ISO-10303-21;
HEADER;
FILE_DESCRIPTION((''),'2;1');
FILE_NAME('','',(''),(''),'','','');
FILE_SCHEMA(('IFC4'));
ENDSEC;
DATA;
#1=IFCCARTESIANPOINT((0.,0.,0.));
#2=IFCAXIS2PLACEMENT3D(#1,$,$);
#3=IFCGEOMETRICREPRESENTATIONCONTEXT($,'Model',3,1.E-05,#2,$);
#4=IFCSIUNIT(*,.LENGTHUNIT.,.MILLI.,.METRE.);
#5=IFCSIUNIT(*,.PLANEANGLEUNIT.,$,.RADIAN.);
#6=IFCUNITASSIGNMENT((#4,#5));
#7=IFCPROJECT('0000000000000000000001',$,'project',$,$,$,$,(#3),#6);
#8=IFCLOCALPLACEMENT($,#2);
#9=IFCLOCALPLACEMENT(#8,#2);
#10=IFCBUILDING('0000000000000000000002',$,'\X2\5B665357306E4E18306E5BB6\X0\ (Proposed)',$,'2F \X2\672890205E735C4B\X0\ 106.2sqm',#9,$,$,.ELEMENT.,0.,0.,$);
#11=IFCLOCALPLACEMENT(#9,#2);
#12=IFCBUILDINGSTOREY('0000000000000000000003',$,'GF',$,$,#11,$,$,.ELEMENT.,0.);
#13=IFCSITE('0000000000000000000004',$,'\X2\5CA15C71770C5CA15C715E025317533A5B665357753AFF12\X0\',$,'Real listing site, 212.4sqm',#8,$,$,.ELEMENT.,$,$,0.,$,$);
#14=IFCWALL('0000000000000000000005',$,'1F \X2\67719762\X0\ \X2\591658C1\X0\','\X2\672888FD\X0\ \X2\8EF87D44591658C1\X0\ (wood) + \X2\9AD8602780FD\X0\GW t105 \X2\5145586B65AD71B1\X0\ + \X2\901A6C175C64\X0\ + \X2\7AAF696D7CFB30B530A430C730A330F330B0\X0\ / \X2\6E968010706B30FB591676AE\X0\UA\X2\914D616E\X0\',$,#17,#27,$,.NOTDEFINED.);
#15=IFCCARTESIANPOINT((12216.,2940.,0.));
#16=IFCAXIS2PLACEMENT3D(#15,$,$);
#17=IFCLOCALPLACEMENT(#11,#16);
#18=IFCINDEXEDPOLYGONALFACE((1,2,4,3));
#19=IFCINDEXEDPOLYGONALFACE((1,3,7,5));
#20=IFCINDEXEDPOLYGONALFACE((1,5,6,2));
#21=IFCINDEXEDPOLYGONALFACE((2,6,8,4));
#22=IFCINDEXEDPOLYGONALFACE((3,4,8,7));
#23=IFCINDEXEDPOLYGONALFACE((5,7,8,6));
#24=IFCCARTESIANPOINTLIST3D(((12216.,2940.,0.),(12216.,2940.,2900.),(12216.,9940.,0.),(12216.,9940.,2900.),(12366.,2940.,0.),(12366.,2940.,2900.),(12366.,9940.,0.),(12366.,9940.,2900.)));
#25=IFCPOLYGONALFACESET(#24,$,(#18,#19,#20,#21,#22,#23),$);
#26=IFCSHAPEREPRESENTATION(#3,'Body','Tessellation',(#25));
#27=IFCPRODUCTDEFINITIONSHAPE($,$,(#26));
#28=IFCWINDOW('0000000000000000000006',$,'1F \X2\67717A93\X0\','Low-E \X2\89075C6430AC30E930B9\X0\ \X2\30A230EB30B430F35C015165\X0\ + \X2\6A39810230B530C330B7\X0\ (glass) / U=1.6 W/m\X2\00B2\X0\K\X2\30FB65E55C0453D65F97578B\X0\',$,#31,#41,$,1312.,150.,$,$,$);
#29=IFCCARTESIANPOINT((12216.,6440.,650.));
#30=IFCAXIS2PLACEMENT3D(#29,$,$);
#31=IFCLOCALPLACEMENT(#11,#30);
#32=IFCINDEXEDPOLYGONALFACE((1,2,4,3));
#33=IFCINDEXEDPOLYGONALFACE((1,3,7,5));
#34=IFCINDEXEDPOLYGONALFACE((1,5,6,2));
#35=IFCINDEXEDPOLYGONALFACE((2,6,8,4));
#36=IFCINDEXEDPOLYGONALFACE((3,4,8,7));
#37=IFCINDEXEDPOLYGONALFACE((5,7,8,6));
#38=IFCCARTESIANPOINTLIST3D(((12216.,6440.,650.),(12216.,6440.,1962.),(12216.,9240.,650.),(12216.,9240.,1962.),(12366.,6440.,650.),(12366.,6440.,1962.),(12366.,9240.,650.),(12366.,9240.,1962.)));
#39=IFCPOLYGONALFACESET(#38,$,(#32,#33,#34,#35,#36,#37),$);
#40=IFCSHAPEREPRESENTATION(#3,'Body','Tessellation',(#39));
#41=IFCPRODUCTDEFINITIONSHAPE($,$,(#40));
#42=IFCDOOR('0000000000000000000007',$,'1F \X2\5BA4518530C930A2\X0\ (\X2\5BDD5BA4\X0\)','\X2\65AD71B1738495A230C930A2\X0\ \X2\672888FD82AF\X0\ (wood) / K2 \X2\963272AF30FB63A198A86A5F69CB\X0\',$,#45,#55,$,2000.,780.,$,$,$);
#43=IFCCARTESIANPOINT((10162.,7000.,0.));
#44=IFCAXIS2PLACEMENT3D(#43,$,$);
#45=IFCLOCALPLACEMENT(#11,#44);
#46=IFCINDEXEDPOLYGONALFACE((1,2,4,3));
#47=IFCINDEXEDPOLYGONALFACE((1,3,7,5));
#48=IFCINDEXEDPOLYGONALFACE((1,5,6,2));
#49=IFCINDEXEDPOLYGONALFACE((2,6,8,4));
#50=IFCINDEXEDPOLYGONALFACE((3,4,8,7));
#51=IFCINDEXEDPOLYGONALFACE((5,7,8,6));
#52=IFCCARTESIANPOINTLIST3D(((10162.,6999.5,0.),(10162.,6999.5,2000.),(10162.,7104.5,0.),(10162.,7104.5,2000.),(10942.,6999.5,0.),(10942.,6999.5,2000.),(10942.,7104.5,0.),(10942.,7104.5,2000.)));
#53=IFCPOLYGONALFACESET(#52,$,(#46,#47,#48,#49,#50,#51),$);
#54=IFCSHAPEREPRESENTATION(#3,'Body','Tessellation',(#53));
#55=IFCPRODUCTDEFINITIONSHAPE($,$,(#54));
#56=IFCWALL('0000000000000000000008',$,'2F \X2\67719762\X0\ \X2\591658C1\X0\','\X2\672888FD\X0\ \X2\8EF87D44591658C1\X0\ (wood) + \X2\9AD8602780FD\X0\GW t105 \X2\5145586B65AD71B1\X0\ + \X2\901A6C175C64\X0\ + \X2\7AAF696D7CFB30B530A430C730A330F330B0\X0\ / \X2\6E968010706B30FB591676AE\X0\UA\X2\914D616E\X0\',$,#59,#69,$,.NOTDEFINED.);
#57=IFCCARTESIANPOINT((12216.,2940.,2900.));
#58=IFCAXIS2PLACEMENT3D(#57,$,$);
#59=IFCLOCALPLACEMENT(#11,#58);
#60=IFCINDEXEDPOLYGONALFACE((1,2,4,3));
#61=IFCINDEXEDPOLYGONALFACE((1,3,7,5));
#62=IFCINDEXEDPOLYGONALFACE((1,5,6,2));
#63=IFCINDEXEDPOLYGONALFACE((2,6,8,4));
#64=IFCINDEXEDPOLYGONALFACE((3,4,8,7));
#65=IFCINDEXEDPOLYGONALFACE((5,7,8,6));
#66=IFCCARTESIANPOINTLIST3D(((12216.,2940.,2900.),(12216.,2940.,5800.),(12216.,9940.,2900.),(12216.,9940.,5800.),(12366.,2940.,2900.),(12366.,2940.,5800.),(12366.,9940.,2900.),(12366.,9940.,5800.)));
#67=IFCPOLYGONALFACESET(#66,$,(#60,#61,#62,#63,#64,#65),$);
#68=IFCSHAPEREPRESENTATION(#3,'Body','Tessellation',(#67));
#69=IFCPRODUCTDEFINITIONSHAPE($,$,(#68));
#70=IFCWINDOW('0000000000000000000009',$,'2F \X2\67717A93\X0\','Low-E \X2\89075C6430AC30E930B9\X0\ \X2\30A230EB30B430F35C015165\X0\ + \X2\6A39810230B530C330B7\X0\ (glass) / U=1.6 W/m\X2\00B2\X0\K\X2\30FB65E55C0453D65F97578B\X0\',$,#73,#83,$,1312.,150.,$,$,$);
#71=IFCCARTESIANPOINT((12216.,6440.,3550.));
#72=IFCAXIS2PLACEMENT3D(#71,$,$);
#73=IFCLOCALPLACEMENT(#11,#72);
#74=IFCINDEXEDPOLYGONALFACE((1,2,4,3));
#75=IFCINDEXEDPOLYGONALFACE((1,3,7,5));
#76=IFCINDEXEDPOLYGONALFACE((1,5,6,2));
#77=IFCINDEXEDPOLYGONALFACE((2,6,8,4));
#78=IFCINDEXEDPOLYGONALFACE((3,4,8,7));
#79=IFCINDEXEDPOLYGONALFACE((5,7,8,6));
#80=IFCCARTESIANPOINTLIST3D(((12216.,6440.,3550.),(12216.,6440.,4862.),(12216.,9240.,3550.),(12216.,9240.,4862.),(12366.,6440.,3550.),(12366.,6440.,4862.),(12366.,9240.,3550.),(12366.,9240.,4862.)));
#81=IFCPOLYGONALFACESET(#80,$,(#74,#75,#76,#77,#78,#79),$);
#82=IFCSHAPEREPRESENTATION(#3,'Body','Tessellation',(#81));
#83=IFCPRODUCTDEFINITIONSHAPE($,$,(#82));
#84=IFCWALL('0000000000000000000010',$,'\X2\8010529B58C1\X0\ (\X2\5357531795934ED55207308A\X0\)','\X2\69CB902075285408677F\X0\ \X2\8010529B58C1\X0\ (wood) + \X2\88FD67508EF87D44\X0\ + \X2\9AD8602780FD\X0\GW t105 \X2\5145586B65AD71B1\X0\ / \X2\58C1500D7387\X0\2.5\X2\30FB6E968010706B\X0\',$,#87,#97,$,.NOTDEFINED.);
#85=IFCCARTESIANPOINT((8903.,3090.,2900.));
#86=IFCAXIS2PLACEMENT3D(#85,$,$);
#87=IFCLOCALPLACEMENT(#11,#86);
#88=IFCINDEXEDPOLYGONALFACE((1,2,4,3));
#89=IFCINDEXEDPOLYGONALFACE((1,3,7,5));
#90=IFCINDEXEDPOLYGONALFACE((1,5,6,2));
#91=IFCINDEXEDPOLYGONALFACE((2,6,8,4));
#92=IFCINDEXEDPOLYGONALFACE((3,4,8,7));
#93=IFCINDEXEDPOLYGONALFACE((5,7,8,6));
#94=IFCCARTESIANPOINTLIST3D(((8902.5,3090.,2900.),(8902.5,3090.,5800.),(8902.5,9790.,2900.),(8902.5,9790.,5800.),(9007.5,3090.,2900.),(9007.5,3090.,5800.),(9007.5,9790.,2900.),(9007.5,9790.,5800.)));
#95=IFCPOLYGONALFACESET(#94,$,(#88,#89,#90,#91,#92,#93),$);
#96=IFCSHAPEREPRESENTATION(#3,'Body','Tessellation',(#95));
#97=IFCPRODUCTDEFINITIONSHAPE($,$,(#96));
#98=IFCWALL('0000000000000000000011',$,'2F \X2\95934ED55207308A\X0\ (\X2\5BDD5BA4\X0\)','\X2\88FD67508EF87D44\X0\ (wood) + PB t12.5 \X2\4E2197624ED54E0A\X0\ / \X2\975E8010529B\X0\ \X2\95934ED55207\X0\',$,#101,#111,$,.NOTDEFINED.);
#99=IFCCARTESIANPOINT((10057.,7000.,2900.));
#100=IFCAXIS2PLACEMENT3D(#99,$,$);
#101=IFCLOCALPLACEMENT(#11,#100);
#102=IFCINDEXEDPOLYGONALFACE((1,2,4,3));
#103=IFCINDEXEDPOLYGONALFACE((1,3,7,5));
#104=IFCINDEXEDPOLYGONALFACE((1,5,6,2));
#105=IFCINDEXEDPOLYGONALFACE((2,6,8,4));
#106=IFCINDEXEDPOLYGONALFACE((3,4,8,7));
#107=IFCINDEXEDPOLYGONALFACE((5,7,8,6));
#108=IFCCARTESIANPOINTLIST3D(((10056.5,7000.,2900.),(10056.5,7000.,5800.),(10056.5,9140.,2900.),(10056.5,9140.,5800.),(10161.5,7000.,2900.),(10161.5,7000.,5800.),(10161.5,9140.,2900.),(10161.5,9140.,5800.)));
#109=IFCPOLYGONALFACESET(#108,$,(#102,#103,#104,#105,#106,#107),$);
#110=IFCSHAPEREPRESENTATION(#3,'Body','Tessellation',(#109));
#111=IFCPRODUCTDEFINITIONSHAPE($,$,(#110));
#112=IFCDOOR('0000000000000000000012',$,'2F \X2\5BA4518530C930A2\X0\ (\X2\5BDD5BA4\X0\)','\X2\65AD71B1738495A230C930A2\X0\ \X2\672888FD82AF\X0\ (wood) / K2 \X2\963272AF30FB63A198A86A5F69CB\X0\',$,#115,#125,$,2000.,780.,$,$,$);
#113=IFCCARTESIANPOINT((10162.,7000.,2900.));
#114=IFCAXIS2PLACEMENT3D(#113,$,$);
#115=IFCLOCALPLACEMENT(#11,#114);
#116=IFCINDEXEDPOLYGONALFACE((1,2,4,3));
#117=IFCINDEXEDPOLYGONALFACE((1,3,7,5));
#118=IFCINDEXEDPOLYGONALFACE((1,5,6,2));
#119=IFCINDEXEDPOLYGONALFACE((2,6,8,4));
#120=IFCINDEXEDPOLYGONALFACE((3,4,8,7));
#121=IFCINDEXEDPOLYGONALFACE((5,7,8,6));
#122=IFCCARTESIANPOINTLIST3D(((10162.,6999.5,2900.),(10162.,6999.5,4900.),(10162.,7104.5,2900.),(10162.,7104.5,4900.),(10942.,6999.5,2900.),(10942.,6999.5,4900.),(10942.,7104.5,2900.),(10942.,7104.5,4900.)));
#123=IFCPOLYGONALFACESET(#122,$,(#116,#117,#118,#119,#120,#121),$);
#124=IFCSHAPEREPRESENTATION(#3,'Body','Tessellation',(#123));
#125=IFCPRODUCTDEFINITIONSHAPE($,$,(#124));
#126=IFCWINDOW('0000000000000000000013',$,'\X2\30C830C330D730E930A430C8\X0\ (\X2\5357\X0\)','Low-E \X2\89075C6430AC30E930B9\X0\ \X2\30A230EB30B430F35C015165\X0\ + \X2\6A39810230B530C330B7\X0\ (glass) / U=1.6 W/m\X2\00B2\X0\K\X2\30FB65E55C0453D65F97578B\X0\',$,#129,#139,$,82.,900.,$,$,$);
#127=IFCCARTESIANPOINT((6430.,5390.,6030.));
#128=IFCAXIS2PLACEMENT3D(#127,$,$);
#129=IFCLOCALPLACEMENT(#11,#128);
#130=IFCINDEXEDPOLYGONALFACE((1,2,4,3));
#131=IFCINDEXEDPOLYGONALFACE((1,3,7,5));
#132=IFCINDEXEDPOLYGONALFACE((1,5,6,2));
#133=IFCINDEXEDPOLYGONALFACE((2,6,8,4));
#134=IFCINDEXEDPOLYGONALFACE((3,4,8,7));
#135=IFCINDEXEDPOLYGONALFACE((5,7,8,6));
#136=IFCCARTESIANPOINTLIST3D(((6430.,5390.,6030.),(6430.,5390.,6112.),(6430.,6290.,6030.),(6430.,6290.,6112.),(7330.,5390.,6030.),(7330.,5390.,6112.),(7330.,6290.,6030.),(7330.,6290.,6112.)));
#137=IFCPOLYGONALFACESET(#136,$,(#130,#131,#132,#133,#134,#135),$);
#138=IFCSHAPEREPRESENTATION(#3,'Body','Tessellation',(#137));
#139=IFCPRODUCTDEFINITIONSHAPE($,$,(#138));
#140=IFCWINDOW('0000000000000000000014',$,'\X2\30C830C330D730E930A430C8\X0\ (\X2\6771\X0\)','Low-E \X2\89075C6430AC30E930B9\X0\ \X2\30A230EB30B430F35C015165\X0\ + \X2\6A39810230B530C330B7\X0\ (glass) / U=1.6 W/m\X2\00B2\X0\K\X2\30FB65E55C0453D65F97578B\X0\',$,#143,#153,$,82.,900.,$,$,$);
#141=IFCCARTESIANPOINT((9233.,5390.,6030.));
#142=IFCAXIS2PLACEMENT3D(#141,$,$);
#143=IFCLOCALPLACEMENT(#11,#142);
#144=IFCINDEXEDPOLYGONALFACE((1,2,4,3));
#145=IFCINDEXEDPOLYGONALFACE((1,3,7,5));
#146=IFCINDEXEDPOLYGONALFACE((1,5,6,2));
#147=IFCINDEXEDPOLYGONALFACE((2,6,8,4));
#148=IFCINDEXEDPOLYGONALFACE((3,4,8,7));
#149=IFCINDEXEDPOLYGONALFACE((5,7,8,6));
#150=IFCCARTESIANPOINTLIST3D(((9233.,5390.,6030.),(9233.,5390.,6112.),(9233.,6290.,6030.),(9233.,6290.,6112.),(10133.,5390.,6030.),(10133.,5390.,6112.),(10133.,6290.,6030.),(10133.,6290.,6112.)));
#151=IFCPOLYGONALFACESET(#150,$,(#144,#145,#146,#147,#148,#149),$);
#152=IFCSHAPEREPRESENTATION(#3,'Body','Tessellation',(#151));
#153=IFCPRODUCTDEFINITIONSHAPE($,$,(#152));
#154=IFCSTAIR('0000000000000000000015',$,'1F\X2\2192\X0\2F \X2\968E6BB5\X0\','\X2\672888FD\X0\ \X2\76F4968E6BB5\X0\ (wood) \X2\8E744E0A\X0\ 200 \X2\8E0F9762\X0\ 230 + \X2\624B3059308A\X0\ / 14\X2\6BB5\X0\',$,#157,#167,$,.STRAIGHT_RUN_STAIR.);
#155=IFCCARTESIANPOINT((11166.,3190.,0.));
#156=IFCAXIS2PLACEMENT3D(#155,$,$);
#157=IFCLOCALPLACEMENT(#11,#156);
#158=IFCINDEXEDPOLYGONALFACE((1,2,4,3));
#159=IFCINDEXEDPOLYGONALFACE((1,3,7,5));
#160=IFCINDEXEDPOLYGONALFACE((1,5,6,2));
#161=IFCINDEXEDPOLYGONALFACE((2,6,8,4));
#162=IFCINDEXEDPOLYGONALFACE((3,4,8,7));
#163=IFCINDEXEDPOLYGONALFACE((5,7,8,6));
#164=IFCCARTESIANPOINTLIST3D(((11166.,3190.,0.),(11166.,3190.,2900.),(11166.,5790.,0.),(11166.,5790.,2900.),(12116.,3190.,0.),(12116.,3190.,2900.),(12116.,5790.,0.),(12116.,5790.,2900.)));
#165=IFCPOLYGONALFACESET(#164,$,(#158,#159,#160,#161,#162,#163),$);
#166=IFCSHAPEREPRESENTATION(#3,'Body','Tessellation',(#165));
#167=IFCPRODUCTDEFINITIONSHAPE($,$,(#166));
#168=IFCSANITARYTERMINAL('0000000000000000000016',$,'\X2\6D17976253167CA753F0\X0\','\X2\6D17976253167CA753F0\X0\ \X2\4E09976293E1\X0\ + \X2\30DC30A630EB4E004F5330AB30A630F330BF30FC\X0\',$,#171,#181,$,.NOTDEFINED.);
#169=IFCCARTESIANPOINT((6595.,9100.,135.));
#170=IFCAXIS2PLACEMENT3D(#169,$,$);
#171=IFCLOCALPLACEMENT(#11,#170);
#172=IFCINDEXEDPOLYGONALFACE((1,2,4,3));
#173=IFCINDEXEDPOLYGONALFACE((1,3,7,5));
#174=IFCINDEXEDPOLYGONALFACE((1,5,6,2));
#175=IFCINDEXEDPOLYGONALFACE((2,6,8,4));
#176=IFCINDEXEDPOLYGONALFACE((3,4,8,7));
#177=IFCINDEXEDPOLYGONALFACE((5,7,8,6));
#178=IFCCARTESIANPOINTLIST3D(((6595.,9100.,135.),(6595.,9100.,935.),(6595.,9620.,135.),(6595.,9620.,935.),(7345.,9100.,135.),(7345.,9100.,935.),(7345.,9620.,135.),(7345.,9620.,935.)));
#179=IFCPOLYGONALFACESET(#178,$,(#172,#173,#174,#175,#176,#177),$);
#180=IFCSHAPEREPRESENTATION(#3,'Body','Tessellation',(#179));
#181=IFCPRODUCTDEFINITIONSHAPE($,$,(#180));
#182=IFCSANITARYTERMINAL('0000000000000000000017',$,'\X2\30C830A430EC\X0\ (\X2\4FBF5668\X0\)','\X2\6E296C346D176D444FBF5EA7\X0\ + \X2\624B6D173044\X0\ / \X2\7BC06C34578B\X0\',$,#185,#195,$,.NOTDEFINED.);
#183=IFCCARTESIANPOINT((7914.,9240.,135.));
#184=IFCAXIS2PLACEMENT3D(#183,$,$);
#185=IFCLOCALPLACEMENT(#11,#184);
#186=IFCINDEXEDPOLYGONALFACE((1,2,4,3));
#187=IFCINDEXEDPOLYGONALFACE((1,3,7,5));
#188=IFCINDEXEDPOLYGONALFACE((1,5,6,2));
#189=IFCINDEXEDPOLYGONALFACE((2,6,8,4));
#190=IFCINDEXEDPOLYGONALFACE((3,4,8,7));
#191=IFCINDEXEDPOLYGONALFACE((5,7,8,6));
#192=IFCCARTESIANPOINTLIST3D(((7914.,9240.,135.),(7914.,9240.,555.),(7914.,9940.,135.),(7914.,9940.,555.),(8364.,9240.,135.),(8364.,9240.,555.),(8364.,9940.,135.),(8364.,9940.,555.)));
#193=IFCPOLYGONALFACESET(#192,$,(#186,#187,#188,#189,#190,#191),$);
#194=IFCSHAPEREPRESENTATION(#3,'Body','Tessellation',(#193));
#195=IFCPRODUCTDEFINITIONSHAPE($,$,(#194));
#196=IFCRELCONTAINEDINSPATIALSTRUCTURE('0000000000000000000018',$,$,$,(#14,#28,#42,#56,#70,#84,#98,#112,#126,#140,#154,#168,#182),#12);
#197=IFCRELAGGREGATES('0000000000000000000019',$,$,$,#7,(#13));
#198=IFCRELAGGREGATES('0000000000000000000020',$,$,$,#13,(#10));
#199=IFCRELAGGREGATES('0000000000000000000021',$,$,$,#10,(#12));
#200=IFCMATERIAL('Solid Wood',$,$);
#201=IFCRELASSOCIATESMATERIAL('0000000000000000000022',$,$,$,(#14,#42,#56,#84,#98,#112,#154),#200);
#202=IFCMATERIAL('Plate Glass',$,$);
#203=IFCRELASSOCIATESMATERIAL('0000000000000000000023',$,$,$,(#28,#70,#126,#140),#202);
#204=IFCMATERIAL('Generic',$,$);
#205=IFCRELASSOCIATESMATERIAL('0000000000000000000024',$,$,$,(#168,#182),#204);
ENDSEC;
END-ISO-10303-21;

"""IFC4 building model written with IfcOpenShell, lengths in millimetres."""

from ifc_helpers import new_model, si_unit, frame, frame_2d, origin, place, context, project, spatial, rectangle, extrude, material, element, fill, save


model = new_model("IFC4")

# Units and contexts
model_context = context("Model", 3, precision=1e-05, world=origin())
ifc_project = project(units=[si_unit("LENGTHUNIT", "METRE", prefix="MILLI"), si_unit("PLANEANGLEUNIT", "RADIAN")], contexts=[model_context])

# Site, building, storey
site_placement = place(None, origin())
site = spatial("IfcSite", under=ifc_project, at=site_placement, Name="岡山県岡山市北区学南町２", ObjectType="Real listing site, 212.4sqm", CompositionType="ELEMENT", RefElevation=0.0)
building_placement = place(site_placement, origin())
building = spatial("IfcBuilding", under=site, at=building_placement, Name="学南の丘の家 (Proposed)", ObjectType="2F 木造平屋 106.2sqm", CompositionType="ELEMENT", ElevationOfRefHeight=0.0, ElevationOfTerrain=0.0)
storey_placement = place(building_placement, origin())
storey = spatial("IfcBuildingStorey", under=building, at=storey_placement, Name="GF", CompositionType="ELEMENT", Elevation=0.0)

# Wall, opening, window
ifc_material_1 = material(Name="Solid Wood")
wall_1_placement = place(storey_placement, frame((12216.0, 2940.0, 0.0)))
wall_1 = element("IfcWall", 1, at=wall_1_placement, inside=storey, material=ifc_material_1, Name="1F 東面 外壁", Description="木製 軸組外壁 (wood) + 高性能GW t105 充填断熱 + 通気層 + 窯業系サイディング / 準耐火・外皮UA配慮", PredefinedType="NOTDEFINED", context=model_context, shape_type="SweptSolid", body=[
    extrude(rectangle(XDim=150.0, YDim=7000.0, at=frame_2d((75.0, 3500.0))), frame((12216.0, 2940.0, 0.0)), (0.0, 0.0, 1.0), 2900.0),
])
opening_1_placement = place(storey_placement, frame((12216.0, 6440.0, 650.0)))
opening_1 = element("IfcOpeningElement", 2, at=opening_1_placement, cuts=wall_1, PredefinedType="NOTDEFINED", context=model_context, shape_type="SweptSolid", body=[
    extrude(rectangle(XDim=150.0, YDim=2800.0, at=frame_2d((75.0, 1400.0))), frame((12216.0, 6440.0, 650.0)), (0.0, 0.0, 1.0), 1312.0),
])
ifc_material_2 = material(Name="Plate Glass")
window_1_placement = place(storey_placement, frame((12216.0, 6440.0, 650.0)))
window_1 = element("IfcWindow", 3, at=window_1_placement, inside=storey, material=ifc_material_2, Name="1F 東窓", Description="Low-E 複層ガラス アルゴン封入 + 樹脂サッシ (glass) / U=1.6 W/m²K・日射取得型", OverallHeight=1312.0, OverallWidth=150.0, context=model_context, shape_type="SweptSolid", body=[
    extrude(rectangle(XDim=150.0, YDim=2800.0, at=frame_2d((75.0, 1400.0))), frame((12216.0, 6440.0, 650.0)), (0.0, 0.0, 1.0), 1312.0),
])
fill(opening_1, window_1)

# Door
door_1_placement = place(storey_placement, frame((10162.0, 7000.0, 0.0)))
element("IfcDoor", 4, at=door_1_placement, inside=storey, material=ifc_material_1, Name="1F 室内ドア (寝室)", Description="断熱玄関ドア 木製芯 (wood) / K2 防犯・採風機構", OverallHeight=2000.0, OverallWidth=780.0, context=model_context, shape_type="SweptSolid", body=[
    extrude(rectangle(XDim=780.0, YDim=105.0, at=frame_2d((390.0, 52.0))), frame((10162.0, 7000.0, 0.0)), (0.0, 0.0, 1.0), 2000.0),
])

# Wall, opening, window
wall_2_placement = place(storey_placement, frame((12216.0, 2940.0, 2900.0)))
wall_2 = element("IfcWall", 5, at=wall_2_placement, inside=storey, material=ifc_material_1, Name="2F 東面 外壁", Description="木製 軸組外壁 (wood) + 高性能GW t105 充填断熱 + 通気層 + 窯業系サイディング / 準耐火・外皮UA配慮", PredefinedType="NOTDEFINED", context=model_context, shape_type="SweptSolid", body=[
    extrude(rectangle(XDim=150.0, YDim=7000.0, at=frame_2d((75.0, 3500.0))), frame((12216.0, 2940.0, 2900.0)), (0.0, 0.0, 1.0), 2900.0),
])
opening_2_placement = place(storey_placement, frame((12216.0, 6440.0, 3550.0)))
opening_2 = element("IfcOpeningElement", 6, at=opening_2_placement, cuts=wall_2, PredefinedType="NOTDEFINED", context=model_context, shape_type="SweptSolid", body=[
    extrude(rectangle(XDim=150.0, YDim=2800.0, at=frame_2d((75.0, 1400.0))), frame((12216.0, 6440.0, 3550.0)), (0.0, 0.0, 1.0), 1312.0),
])
window_2_placement = place(storey_placement, frame((12216.0, 6440.0, 3550.0)))
window_2 = element("IfcWindow", 7, at=window_2_placement, inside=storey, material=ifc_material_2, Name="2F 東窓", Description="Low-E 複層ガラス アルゴン封入 + 樹脂サッシ (glass) / U=1.6 W/m²K・日射取得型", OverallHeight=1312.0, OverallWidth=150.0, context=model_context, shape_type="SweptSolid", body=[
    extrude(rectangle(XDim=150.0, YDim=2800.0, at=frame_2d((75.0, 1400.0))), frame((12216.0, 6440.0, 3550.0)), (0.0, 0.0, 1.0), 1312.0),
])
fill(opening_2, window_2)

# Walls
wall_3_placement = place(storey_placement, frame((8903.0, 3090.0, 2900.0)))
element("IfcWall", 8, at=wall_3_placement, inside=storey, material=ifc_material_1, Name="耐力壁 (南北間仕切り)", Description="構造用合板 耐力壁 (wood) + 製材軸組 + 高性能GW t105 充填断熱 / 壁倍率2.5・準耐火", PredefinedType="NOTDEFINED", context=model_context, shape_type="SweptSolid", body=[
    extrude(rectangle(XDim=105.0, YDim=6700.0, at=frame_2d((52.0, 3350.0))), frame((8903.0, 3090.0, 2900.0)), (0.0, 0.0, 1.0), 2900.0),
])
wall_4_placement = place(storey_placement, frame((10057.0, 7000.0, 2900.0)))
element("IfcWall", 9, at=wall_4_placement, inside=storey, material=ifc_material_1, Name="2F 間仕切り (寝室)", Description="製材軸組 (wood) + PB t12.5 両面仕上 / 非耐力 間仕切", PredefinedType="NOTDEFINED", context=model_context, shape_type="SweptSolid", body=[
    extrude(rectangle(XDim=105.0, YDim=2140.0, at=frame_2d((52.0, 1070.0))), frame((10057.0, 7000.0, 2900.0)), (0.0, 0.0, 1.0), 2900.0),
])

# Door
door_2_placement = place(storey_placement, frame((10162.0, 7000.0, 2900.0)))
element("IfcDoor", 10, at=door_2_placement, inside=storey, material=ifc_material_1, Name="2F 室内ドア (寝室)", Description="断熱玄関ドア 木製芯 (wood) / K2 防犯・採風機構", OverallHeight=2000.0, OverallWidth=780.0, context=model_context, shape_type="SweptSolid", body=[
    extrude(rectangle(XDim=780.0, YDim=105.0, at=frame_2d((390.0, 52.0))), frame((10162.0, 7000.0, 2900.0)), (0.0, 0.0, 1.0), 2000.0),
])

# Windows
window_3_placement = place(storey_placement, frame((6430.0, 5390.0, 6030.0)))
element("IfcWindow", 11, at=window_3_placement, inside=storey, material=ifc_material_2, Name="トップライト (南)", Description="Low-E 複層ガラス アルゴン封入 + 樹脂サッシ (glass) / U=1.6 W/m²K・日射取得型", OverallHeight=82.0, OverallWidth=900.0, context=model_context, shape_type="SweptSolid", body=[
    extrude(rectangle(XDim=900.0, YDim=900.0, at=frame_2d((450.0, 450.0))), frame((6430.0, 5390.0, 6030.0)), (0.0, 0.0, 1.0), 82.0),
])
window_4_placement = place(storey_placement, frame((9233.0, 5390.0, 6030.0)))
element("IfcWindow", 12, at=window_4_placement, inside=storey, material=ifc_material_2, Name="トップライト (東)", Description="Low-E 複層ガラス アルゴン封入 + 樹脂サッシ (glass) / U=1.6 W/m²K・日射取得型", OverallHeight=82.0, OverallWidth=900.0, context=model_context, shape_type="SweptSolid", body=[
    extrude(rectangle(XDim=900.0, YDim=900.0, at=frame_2d((450.0, 450.0))), frame((9233.0, 5390.0, 6030.0)), (0.0, 0.0, 1.0), 82.0),
])

# Stair
stair_placement = place(storey_placement, frame((11166.0, 3190.0, 0.0)))
element("IfcStair", 13, at=stair_placement, inside=storey, material=ifc_material_1, Name="1F→2F 階段", Description="木製 直階段 (wood) 蹴上 200 踏面 230 + 手すり / 14段", PredefinedType="STRAIGHT_RUN_STAIR", context=model_context, shape_type="SweptSolid", body=[
    extrude(rectangle(XDim=950.0, YDim=2600.0, at=frame_2d((475.0, 1300.0))), frame((11166.0, 3190.0, 0.0)), (0.0, 0.0, 1.0), 2900.0),
])

# Sanitary terminals
ifc_material_3 = material(Name="Generic")
sanitary_terminal_1_placement = place(storey_placement, frame((6595.0, 9100.0, 135.0)))
element("IfcSanitaryTerminal", 14, at=sanitary_terminal_1_placement, inside=storey, material=ifc_material_3, Name="洗面化粧台", Description="洗面化粧台 三面鏡 + ボウル一体カウンター", PredefinedType="NOTDEFINED", context=model_context, shape_type="SweptSolid", body=[
    extrude(rectangle(XDim=750.0, YDim=520.0, at=frame_2d((375.0, 260.0))), frame((6595.0, 9100.0, 135.0)), (0.0, 0.0, 1.0), 800.0),
])
sanitary_terminal_2_placement = place(storey_placement, frame((7914.0, 9240.0, 135.0)))
element("IfcSanitaryTerminal", 15, at=sanitary_terminal_2_placement, inside=storey, material=ifc_material_3, Name="トイレ (便器)", Description="温水洗浄便座 + 手洗い / 節水型", PredefinedType="NOTDEFINED", context=model_context, shape_type="SweptSolid", body=[
    extrude(rectangle(XDim=450.0, YDim=700.0, at=frame_2d((225.0, 350.0))), frame((7914.0, 9240.0, 135.0)), (0.0, 0.0, 1.0), 420.0),
])

save(model, "model.ifc")
